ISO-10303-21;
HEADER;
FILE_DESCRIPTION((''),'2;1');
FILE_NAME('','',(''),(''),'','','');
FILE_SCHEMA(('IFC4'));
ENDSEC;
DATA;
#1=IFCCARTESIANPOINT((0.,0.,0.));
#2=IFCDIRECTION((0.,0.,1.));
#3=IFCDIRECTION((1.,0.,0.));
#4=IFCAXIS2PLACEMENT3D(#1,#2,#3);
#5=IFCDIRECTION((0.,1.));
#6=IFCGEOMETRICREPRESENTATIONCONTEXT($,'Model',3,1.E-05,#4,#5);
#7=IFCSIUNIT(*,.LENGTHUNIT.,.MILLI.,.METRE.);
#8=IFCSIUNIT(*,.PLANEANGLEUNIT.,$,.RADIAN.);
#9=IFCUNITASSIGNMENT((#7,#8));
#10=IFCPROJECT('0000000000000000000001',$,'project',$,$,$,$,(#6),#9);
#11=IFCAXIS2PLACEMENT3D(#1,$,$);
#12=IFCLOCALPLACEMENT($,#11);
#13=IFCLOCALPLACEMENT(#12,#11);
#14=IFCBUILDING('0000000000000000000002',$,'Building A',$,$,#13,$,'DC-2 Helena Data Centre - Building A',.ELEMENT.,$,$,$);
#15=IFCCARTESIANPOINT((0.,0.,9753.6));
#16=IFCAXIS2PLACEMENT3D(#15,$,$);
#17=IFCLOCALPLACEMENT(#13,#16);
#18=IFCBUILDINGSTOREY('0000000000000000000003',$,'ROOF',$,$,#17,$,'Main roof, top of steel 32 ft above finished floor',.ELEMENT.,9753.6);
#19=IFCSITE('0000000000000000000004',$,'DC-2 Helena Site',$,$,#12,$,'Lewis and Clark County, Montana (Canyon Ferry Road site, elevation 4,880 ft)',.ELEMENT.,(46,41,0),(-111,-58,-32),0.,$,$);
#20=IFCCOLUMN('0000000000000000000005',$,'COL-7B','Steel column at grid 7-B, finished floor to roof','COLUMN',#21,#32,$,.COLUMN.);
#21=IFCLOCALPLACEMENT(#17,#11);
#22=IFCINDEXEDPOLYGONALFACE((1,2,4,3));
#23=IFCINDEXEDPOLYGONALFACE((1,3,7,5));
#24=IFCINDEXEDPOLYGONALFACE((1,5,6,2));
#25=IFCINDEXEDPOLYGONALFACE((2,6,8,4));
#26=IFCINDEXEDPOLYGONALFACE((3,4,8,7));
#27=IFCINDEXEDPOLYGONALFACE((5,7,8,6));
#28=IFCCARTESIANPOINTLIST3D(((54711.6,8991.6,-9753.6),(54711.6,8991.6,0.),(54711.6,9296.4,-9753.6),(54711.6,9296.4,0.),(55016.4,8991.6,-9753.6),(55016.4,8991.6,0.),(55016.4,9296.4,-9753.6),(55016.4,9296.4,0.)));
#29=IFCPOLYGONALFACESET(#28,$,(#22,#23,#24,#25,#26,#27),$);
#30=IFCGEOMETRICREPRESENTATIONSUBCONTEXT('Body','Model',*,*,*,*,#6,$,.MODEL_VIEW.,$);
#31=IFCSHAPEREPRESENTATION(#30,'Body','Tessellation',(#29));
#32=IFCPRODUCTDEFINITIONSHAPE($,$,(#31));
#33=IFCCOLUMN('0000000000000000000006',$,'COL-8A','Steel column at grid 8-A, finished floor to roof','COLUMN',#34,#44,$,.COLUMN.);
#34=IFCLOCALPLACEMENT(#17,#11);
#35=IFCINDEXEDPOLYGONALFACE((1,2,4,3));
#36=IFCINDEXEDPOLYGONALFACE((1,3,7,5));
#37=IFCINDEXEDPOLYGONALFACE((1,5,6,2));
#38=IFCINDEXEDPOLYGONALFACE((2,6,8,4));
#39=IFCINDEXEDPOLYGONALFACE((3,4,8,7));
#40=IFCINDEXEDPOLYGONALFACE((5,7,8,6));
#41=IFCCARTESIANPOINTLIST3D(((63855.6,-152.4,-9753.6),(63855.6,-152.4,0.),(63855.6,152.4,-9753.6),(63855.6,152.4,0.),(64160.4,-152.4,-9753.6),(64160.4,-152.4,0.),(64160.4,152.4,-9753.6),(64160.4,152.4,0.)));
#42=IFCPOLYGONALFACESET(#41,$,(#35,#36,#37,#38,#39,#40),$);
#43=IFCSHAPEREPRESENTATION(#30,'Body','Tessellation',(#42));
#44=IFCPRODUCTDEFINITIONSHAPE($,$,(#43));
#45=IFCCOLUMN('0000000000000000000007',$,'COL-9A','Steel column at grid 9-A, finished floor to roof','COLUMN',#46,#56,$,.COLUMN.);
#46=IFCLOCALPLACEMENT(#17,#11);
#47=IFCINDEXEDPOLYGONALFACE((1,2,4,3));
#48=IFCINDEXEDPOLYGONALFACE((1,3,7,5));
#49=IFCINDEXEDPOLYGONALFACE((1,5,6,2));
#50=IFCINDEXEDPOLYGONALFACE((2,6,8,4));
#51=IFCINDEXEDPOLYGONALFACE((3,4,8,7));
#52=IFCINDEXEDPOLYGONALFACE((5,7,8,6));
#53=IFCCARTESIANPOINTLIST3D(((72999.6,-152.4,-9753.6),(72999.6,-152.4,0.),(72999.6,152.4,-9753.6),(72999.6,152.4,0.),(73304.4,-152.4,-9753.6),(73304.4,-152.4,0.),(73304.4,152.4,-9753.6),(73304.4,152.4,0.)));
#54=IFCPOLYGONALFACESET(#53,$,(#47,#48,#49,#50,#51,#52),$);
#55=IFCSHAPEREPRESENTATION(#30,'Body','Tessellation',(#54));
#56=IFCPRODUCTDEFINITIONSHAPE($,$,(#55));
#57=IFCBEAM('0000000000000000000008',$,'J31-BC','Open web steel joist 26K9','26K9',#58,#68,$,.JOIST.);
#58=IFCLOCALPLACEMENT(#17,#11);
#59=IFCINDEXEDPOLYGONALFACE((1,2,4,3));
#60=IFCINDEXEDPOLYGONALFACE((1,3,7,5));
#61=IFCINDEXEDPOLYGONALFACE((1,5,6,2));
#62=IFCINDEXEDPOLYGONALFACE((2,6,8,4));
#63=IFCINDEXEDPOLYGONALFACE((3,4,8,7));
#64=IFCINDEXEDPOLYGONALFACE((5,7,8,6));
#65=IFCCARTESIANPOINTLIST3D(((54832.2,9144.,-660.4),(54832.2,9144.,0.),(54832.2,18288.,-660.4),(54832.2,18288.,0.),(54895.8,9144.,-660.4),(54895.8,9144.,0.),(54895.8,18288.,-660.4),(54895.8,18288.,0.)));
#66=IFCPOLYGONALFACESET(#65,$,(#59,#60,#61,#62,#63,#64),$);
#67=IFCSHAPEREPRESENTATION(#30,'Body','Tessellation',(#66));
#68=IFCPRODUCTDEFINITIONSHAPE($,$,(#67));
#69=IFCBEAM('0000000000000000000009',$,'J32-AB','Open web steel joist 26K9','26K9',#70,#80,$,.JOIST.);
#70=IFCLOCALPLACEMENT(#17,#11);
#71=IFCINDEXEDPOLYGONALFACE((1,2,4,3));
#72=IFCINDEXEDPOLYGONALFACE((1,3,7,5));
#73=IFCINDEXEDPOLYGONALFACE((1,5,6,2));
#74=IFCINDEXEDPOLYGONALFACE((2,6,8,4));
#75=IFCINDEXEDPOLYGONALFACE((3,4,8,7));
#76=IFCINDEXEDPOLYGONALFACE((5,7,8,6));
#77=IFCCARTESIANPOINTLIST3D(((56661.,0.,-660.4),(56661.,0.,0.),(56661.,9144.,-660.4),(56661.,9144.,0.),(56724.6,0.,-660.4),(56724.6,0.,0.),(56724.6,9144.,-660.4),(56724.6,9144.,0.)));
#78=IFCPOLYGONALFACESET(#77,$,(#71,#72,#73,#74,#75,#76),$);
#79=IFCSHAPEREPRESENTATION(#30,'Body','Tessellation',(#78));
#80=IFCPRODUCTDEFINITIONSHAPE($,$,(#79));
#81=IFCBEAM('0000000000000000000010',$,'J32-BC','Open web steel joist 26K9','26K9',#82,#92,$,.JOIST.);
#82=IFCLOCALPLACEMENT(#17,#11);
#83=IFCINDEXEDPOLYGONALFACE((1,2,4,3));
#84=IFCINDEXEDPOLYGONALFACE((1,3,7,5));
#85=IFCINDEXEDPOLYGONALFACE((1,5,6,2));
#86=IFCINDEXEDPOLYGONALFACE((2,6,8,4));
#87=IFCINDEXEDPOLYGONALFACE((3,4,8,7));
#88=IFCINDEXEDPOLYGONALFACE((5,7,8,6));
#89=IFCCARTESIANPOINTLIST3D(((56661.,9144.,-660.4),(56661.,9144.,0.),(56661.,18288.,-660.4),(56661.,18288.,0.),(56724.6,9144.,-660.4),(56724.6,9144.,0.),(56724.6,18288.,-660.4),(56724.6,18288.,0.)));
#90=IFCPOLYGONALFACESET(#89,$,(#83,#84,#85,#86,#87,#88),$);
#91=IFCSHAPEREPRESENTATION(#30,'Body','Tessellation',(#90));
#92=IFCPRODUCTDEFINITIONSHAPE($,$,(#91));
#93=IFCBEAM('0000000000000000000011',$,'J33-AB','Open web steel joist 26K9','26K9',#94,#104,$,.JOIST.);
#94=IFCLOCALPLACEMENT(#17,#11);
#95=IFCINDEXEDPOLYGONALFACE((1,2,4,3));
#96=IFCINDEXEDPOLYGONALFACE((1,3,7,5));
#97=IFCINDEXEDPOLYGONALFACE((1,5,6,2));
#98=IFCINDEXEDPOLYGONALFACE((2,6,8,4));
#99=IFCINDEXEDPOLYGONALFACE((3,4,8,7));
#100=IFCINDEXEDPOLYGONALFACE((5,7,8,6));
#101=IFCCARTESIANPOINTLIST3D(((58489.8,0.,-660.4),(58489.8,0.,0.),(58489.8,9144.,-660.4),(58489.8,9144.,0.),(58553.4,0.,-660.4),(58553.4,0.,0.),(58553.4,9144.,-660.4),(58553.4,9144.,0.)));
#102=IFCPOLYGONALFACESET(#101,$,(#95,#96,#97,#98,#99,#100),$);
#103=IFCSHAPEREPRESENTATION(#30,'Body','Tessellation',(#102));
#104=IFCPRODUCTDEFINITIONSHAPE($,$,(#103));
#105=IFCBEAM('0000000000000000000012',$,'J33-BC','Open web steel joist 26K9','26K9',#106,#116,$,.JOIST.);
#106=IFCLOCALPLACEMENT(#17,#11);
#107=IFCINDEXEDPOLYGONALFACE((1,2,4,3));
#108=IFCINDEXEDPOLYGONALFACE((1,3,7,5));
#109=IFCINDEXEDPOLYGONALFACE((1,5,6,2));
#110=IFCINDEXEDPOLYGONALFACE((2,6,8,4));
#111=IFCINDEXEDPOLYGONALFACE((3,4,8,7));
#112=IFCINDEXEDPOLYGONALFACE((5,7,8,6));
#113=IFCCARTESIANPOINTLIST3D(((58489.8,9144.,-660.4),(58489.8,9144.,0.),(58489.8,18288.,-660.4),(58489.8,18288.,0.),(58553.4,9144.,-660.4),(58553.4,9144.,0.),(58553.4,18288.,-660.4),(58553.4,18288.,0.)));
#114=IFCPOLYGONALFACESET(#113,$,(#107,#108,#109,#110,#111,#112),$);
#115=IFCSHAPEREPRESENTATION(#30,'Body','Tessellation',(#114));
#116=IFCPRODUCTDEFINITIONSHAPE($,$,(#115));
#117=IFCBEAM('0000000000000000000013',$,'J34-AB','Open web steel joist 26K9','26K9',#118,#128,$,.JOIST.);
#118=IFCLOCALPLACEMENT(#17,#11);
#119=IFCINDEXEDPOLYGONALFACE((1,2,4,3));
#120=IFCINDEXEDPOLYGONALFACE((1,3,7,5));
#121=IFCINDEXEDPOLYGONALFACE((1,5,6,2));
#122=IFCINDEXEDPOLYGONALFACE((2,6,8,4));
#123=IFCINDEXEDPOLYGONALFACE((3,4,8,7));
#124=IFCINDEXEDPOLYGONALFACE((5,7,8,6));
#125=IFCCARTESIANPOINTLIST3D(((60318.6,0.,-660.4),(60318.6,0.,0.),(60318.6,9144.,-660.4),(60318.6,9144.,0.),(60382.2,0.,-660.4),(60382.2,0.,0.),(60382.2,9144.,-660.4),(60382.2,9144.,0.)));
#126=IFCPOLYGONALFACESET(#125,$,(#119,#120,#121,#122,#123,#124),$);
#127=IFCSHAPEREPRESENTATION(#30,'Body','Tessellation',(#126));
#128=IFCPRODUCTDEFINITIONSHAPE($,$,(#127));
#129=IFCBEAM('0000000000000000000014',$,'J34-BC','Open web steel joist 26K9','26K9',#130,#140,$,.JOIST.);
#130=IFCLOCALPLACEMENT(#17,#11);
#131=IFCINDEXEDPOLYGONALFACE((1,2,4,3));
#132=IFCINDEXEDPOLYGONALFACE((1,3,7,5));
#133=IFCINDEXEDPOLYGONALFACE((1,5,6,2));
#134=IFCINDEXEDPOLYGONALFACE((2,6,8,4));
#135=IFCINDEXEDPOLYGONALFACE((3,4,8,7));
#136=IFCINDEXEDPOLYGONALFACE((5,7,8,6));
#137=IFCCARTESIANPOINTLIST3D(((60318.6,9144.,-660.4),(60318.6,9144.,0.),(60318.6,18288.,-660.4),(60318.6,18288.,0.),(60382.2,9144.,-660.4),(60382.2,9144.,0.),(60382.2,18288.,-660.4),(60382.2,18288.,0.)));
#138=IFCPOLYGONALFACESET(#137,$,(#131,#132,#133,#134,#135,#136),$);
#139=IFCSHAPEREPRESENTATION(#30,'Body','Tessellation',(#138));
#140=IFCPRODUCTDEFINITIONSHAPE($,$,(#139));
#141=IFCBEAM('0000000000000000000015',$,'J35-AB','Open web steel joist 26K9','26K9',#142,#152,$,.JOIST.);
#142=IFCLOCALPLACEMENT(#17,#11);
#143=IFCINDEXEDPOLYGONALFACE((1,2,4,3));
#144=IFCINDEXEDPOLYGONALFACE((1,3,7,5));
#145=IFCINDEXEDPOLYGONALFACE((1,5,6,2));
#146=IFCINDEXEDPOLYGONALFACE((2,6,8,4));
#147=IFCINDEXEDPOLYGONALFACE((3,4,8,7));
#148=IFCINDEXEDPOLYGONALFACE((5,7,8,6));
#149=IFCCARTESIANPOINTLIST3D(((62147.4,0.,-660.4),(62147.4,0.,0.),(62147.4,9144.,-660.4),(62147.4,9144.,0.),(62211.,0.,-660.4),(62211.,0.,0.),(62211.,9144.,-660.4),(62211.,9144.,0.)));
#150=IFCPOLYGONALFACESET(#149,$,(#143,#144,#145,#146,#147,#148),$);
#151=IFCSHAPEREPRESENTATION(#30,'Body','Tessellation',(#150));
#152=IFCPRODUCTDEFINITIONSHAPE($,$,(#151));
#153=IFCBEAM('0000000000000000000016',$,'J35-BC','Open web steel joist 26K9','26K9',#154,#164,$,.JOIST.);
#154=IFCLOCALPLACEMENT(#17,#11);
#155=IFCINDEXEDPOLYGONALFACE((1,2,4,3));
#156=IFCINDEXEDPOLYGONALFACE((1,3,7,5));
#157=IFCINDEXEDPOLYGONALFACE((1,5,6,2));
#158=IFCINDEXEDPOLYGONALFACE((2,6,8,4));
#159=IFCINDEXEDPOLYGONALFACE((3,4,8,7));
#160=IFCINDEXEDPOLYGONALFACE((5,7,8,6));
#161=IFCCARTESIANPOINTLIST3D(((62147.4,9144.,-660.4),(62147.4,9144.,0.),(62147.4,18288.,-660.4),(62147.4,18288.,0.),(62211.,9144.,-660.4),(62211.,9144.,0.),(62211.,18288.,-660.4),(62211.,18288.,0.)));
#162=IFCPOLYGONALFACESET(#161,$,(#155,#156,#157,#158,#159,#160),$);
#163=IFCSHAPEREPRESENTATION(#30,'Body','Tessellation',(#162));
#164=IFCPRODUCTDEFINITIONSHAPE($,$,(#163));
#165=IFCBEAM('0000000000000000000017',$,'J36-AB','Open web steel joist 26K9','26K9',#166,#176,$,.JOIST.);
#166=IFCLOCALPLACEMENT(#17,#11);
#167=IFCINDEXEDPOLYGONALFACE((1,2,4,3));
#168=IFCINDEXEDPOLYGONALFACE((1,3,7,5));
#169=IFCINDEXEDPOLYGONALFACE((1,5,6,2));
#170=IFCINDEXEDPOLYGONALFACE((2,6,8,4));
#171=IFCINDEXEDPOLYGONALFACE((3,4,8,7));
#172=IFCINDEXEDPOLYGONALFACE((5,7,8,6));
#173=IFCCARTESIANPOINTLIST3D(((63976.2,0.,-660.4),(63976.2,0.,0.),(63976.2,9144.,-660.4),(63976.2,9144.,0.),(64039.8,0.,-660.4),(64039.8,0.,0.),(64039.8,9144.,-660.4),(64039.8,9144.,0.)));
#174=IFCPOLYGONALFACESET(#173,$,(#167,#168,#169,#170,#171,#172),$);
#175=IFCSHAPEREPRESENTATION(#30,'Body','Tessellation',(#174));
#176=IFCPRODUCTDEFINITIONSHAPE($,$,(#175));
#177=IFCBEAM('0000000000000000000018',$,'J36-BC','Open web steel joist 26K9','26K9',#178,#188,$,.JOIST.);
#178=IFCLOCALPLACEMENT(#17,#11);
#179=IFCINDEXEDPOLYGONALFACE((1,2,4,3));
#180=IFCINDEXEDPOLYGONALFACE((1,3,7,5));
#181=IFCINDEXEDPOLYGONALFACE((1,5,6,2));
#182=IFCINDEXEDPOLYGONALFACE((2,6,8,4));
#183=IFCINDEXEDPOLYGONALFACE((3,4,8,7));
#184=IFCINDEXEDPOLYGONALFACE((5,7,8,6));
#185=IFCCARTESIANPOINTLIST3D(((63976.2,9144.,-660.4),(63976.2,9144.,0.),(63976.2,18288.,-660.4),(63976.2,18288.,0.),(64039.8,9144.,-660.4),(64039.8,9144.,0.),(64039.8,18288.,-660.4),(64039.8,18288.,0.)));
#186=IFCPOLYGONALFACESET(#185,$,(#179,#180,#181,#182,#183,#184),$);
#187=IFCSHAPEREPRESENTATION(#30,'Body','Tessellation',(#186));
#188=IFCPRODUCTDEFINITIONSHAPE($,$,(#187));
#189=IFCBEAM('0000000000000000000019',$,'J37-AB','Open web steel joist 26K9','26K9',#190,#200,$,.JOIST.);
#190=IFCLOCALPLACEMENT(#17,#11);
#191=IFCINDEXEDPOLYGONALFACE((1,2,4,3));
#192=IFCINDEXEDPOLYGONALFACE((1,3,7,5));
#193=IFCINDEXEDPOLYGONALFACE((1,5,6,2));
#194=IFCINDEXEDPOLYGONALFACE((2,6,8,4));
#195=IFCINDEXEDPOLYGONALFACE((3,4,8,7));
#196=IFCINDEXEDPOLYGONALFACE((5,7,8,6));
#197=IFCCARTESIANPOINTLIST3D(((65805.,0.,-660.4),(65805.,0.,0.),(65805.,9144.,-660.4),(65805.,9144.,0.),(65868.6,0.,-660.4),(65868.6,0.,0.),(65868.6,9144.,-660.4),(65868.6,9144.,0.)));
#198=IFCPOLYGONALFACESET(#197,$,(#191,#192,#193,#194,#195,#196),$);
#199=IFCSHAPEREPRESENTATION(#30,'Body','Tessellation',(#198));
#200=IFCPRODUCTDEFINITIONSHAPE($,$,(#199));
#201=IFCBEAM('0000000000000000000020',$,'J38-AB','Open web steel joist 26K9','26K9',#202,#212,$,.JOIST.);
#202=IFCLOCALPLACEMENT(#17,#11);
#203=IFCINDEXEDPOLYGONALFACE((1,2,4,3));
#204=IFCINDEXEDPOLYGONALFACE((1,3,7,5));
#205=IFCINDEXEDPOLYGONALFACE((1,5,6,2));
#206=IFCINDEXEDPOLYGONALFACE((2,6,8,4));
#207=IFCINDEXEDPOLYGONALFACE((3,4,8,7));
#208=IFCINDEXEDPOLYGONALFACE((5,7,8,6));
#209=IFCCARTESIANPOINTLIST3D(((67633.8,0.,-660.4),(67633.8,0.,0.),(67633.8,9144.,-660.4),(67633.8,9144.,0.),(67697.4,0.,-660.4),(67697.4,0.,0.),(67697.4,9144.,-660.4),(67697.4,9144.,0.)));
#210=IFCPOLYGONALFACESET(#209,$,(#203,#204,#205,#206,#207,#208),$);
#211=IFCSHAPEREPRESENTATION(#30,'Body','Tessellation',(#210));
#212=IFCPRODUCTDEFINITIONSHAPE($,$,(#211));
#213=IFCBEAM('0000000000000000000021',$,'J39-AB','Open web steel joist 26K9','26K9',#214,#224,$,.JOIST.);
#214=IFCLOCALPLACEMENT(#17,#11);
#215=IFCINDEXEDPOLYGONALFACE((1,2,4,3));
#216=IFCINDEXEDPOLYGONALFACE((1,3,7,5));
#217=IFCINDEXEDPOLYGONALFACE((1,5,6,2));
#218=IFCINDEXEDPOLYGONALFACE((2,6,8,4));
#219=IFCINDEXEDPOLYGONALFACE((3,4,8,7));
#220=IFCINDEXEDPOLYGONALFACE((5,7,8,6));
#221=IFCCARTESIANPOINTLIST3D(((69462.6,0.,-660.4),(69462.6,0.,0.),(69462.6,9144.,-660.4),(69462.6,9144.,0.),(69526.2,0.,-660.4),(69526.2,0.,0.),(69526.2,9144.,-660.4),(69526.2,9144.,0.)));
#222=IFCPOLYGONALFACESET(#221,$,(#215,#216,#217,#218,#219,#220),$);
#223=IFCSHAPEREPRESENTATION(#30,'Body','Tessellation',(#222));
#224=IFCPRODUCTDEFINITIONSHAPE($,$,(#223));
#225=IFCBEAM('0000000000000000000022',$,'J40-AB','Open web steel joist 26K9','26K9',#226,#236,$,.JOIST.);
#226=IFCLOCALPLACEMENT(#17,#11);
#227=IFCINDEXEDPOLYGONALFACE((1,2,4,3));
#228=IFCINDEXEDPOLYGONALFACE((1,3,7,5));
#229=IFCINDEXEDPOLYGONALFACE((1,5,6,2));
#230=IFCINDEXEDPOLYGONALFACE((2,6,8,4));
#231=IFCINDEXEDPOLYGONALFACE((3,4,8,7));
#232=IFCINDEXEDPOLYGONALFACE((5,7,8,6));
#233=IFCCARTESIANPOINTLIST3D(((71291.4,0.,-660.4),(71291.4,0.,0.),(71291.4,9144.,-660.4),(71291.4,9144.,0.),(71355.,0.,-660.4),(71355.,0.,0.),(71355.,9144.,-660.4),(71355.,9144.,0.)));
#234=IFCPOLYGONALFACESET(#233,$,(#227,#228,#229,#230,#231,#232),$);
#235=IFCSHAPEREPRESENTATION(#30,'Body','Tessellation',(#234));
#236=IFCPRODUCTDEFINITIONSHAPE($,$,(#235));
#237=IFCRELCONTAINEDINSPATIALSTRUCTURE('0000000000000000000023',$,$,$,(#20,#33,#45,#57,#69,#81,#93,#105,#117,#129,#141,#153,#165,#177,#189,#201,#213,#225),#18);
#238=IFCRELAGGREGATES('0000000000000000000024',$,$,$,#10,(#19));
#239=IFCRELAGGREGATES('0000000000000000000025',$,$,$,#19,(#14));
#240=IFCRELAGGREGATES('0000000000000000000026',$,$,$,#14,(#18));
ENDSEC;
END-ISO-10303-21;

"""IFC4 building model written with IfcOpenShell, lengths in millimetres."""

from ifc_helpers import new_model, si_unit, direction, frame, origin, origin_with_axes, origin_2d, place, context, subcontext, project, spatial, rectangle, extrude, element, save


model = new_model("IFC4")

# Units and contexts
model_context = context("Model", 3, precision=1e-05, world=origin_with_axes(), true_north=direction((0.0, 1.0)))
body_context = subcontext(model_context, "Body", "Model", "MODEL_VIEW")
ifc_project = project(units=[si_unit("LENGTHUNIT", "METRE", prefix="MILLI"), si_unit("PLANEANGLEUNIT", "RADIAN")], contexts=[model_context])

# Site, building, storey
site_placement = place(None, origin())
site = spatial("IfcSite", under=ifc_project, at=site_placement, Name="DC-2 Helena Site", LongName="Lewis and Clark County, Montana (Canyon Ferry Road site, elevation 4,880 ft)", CompositionType="ELEMENT", RefLatitude=(46, 41, 0), RefLongitude=(-111, -58, -32), RefElevation=0.0)
building_placement = place(site_placement, origin())
building = spatial("IfcBuilding", under=site, at=building_placement, Name="Building A", LongName="DC-2 Helena Data Centre - Building A", CompositionType="ELEMENT")
storey_placement = place(building_placement, frame((0.0, 0.0, 9753.6)))
storey = spatial("IfcBuildingStorey", under=building, at=storey_placement, Name="ROOF", LongName="Main roof, top of steel 32 ft above finished floor", CompositionType="ELEMENT", Elevation=9753.6)

# Columns
column_1_placement = place(storey_placement, frame((54864.0, 9144.0, -9753.6)))
element("IfcColumn", 1, at=column_1_placement, inside=storey, Name="COL-7B", Description="Steel column at grid 7-B, finished floor to roof", ObjectType="COLUMN", PredefinedType="COLUMN", context=body_context, shape_type="SweptSolid", body=[
    extrude(rectangle(XDim=304.8, YDim=304.8, at=origin_2d()), origin(), (0.0, 0.0, 1.0), 9753.6),
])
placement_1 = place(storey_placement, frame((64008.0, 0.0, -9753.6)))
element("IfcColumn", 2, at=placement_1, inside=storey, Name="COL-8A", Description="Steel column at grid 8-A, finished floor to roof", ObjectType="COLUMN", PredefinedType="COLUMN", context=body_context, shape_type="SweptSolid", body=[
    extrude(rectangle(XDim=304.8, YDim=304.8, at=origin_2d()), origin(), (0.0, 0.0, 1.0), 9753.6),
])
column_2_placement = place(storey_placement, frame((73152.0, 0.0, -9753.6)))
element("IfcColumn", 3, at=column_2_placement, inside=storey, Name="COL-9A", Description="Steel column at grid 9-A, finished floor to roof", ObjectType="COLUMN", PredefinedType="COLUMN", context=body_context, shape_type="SweptSolid", body=[
    extrude(rectangle(XDim=304.8, YDim=304.8, at=origin_2d()), origin(), (0.0, 0.0, 1.0), 9753.6),
])

# Beams
placement_2 = place(storey_placement, frame((54864.0, 9144.0, 0.0)))
element("IfcBeam", 4, at=placement_2, inside=storey, Name="J31-BC", Description="Open web steel joist 26K9", ObjectType="26K9", PredefinedType="JOIST", context=body_context, shape_type="SweptSolid", body=[
    extrude(rectangle(XDim=63.5, YDim=660.4, at=origin_2d()), frame((0.0, 0.0, -330.2), z_axis=(0.0, 1.0, 0.0), x_axis=(1.0, 0.0, 0.0)), (0.0, 0.0, 1.0), 9144.0),
])
for number, where, name in (
    (5, (56692.8, 0.0, 0.0), "J32-AB"),
    (6, (56692.8, 9144.0, 0.0), "J32-BC"),
    (7, (58521.6, 0.0, 0.0), "J33-AB"),
    (8, (58521.6, 9144.0, 0.0), "J33-BC"),
    (9, (60350.4, 0.0, 0.0), "J34-AB"),
    (10, (60350.4, 9144.0, 0.0), "J34-BC"),
    (11, (62179.2, 0.0, 0.0), "J35-AB"),
    (12, (62179.2, 9144.0, 0.0), "J35-BC"),
):
    element("IfcBeam", number, at=place(storey_placement, frame(where)), inside=storey, Name=name, Description="Open web steel joist 26K9", ObjectType="26K9", PredefinedType="JOIST", context=body_context, shape_type="SweptSolid", body=[
        extrude(rectangle(XDim=63.5, YDim=660.4, at=origin_2d()), frame((0.0, 0.0, -330.2), z_axis=(0.0, 1.0, 0.0), x_axis=(1.0, 0.0, 0.0)), (0.0, 0.0, 1.0), 9144.0),
    ])
placement_3 = place(storey_placement, frame((64008.0, 0.0, 0.0)))
element("IfcBeam", 13, at=placement_3, inside=storey, Name="J36-AB", Description="Open web steel joist 26K9", ObjectType="26K9", PredefinedType="JOIST", context=body_context, shape_type="SweptSolid", body=[
    extrude(rectangle(XDim=63.5, YDim=660.4, at=origin_2d()), frame((0.0, 0.0, -330.2), z_axis=(0.0, 1.0, 0.0), x_axis=(1.0, 0.0, 0.0)), (0.0, 0.0, 1.0), 9144.0),
])
placement_4 = place(storey_placement, frame((64008.0, 9144.0, 0.0)))
element("IfcBeam", 14, at=placement_4, inside=storey, Name="J36-BC", Description="Open web steel joist 26K9", ObjectType="26K9", PredefinedType="JOIST", context=body_context, shape_type="SweptSolid", body=[
    extrude(rectangle(XDim=63.5, YDim=660.4, at=origin_2d()), frame((0.0, 0.0, -330.2), z_axis=(0.0, 1.0, 0.0), x_axis=(1.0, 0.0, 0.0)), (0.0, 0.0, 1.0), 9144.0),
])
for number, where, name in (
    (15, (65836.8, 0.0, 0.0), "J37-AB"),
    (16, (67665.6, 0.0, 0.0), "J38-AB"),
    (17, (69494.4, 0.0, 0.0), "J39-AB"),
    (18, (71323.2, 0.0, 0.0), "J40-AB"),
):
    element("IfcBeam", number, at=place(storey_placement, frame(where)), inside=storey, Name=name, Description="Open web steel joist 26K9", ObjectType="26K9", PredefinedType="JOIST", context=body_context, shape_type="SweptSolid", body=[
        extrude(rectangle(XDim=63.5, YDim=660.4, at=origin_2d()), frame((0.0, 0.0, -330.2), z_axis=(0.0, 1.0, 0.0), x_axis=(1.0, 0.0, 0.0)), (0.0, 0.0, 1.0), 9144.0),
    ])

save(model, "model.ifc")
